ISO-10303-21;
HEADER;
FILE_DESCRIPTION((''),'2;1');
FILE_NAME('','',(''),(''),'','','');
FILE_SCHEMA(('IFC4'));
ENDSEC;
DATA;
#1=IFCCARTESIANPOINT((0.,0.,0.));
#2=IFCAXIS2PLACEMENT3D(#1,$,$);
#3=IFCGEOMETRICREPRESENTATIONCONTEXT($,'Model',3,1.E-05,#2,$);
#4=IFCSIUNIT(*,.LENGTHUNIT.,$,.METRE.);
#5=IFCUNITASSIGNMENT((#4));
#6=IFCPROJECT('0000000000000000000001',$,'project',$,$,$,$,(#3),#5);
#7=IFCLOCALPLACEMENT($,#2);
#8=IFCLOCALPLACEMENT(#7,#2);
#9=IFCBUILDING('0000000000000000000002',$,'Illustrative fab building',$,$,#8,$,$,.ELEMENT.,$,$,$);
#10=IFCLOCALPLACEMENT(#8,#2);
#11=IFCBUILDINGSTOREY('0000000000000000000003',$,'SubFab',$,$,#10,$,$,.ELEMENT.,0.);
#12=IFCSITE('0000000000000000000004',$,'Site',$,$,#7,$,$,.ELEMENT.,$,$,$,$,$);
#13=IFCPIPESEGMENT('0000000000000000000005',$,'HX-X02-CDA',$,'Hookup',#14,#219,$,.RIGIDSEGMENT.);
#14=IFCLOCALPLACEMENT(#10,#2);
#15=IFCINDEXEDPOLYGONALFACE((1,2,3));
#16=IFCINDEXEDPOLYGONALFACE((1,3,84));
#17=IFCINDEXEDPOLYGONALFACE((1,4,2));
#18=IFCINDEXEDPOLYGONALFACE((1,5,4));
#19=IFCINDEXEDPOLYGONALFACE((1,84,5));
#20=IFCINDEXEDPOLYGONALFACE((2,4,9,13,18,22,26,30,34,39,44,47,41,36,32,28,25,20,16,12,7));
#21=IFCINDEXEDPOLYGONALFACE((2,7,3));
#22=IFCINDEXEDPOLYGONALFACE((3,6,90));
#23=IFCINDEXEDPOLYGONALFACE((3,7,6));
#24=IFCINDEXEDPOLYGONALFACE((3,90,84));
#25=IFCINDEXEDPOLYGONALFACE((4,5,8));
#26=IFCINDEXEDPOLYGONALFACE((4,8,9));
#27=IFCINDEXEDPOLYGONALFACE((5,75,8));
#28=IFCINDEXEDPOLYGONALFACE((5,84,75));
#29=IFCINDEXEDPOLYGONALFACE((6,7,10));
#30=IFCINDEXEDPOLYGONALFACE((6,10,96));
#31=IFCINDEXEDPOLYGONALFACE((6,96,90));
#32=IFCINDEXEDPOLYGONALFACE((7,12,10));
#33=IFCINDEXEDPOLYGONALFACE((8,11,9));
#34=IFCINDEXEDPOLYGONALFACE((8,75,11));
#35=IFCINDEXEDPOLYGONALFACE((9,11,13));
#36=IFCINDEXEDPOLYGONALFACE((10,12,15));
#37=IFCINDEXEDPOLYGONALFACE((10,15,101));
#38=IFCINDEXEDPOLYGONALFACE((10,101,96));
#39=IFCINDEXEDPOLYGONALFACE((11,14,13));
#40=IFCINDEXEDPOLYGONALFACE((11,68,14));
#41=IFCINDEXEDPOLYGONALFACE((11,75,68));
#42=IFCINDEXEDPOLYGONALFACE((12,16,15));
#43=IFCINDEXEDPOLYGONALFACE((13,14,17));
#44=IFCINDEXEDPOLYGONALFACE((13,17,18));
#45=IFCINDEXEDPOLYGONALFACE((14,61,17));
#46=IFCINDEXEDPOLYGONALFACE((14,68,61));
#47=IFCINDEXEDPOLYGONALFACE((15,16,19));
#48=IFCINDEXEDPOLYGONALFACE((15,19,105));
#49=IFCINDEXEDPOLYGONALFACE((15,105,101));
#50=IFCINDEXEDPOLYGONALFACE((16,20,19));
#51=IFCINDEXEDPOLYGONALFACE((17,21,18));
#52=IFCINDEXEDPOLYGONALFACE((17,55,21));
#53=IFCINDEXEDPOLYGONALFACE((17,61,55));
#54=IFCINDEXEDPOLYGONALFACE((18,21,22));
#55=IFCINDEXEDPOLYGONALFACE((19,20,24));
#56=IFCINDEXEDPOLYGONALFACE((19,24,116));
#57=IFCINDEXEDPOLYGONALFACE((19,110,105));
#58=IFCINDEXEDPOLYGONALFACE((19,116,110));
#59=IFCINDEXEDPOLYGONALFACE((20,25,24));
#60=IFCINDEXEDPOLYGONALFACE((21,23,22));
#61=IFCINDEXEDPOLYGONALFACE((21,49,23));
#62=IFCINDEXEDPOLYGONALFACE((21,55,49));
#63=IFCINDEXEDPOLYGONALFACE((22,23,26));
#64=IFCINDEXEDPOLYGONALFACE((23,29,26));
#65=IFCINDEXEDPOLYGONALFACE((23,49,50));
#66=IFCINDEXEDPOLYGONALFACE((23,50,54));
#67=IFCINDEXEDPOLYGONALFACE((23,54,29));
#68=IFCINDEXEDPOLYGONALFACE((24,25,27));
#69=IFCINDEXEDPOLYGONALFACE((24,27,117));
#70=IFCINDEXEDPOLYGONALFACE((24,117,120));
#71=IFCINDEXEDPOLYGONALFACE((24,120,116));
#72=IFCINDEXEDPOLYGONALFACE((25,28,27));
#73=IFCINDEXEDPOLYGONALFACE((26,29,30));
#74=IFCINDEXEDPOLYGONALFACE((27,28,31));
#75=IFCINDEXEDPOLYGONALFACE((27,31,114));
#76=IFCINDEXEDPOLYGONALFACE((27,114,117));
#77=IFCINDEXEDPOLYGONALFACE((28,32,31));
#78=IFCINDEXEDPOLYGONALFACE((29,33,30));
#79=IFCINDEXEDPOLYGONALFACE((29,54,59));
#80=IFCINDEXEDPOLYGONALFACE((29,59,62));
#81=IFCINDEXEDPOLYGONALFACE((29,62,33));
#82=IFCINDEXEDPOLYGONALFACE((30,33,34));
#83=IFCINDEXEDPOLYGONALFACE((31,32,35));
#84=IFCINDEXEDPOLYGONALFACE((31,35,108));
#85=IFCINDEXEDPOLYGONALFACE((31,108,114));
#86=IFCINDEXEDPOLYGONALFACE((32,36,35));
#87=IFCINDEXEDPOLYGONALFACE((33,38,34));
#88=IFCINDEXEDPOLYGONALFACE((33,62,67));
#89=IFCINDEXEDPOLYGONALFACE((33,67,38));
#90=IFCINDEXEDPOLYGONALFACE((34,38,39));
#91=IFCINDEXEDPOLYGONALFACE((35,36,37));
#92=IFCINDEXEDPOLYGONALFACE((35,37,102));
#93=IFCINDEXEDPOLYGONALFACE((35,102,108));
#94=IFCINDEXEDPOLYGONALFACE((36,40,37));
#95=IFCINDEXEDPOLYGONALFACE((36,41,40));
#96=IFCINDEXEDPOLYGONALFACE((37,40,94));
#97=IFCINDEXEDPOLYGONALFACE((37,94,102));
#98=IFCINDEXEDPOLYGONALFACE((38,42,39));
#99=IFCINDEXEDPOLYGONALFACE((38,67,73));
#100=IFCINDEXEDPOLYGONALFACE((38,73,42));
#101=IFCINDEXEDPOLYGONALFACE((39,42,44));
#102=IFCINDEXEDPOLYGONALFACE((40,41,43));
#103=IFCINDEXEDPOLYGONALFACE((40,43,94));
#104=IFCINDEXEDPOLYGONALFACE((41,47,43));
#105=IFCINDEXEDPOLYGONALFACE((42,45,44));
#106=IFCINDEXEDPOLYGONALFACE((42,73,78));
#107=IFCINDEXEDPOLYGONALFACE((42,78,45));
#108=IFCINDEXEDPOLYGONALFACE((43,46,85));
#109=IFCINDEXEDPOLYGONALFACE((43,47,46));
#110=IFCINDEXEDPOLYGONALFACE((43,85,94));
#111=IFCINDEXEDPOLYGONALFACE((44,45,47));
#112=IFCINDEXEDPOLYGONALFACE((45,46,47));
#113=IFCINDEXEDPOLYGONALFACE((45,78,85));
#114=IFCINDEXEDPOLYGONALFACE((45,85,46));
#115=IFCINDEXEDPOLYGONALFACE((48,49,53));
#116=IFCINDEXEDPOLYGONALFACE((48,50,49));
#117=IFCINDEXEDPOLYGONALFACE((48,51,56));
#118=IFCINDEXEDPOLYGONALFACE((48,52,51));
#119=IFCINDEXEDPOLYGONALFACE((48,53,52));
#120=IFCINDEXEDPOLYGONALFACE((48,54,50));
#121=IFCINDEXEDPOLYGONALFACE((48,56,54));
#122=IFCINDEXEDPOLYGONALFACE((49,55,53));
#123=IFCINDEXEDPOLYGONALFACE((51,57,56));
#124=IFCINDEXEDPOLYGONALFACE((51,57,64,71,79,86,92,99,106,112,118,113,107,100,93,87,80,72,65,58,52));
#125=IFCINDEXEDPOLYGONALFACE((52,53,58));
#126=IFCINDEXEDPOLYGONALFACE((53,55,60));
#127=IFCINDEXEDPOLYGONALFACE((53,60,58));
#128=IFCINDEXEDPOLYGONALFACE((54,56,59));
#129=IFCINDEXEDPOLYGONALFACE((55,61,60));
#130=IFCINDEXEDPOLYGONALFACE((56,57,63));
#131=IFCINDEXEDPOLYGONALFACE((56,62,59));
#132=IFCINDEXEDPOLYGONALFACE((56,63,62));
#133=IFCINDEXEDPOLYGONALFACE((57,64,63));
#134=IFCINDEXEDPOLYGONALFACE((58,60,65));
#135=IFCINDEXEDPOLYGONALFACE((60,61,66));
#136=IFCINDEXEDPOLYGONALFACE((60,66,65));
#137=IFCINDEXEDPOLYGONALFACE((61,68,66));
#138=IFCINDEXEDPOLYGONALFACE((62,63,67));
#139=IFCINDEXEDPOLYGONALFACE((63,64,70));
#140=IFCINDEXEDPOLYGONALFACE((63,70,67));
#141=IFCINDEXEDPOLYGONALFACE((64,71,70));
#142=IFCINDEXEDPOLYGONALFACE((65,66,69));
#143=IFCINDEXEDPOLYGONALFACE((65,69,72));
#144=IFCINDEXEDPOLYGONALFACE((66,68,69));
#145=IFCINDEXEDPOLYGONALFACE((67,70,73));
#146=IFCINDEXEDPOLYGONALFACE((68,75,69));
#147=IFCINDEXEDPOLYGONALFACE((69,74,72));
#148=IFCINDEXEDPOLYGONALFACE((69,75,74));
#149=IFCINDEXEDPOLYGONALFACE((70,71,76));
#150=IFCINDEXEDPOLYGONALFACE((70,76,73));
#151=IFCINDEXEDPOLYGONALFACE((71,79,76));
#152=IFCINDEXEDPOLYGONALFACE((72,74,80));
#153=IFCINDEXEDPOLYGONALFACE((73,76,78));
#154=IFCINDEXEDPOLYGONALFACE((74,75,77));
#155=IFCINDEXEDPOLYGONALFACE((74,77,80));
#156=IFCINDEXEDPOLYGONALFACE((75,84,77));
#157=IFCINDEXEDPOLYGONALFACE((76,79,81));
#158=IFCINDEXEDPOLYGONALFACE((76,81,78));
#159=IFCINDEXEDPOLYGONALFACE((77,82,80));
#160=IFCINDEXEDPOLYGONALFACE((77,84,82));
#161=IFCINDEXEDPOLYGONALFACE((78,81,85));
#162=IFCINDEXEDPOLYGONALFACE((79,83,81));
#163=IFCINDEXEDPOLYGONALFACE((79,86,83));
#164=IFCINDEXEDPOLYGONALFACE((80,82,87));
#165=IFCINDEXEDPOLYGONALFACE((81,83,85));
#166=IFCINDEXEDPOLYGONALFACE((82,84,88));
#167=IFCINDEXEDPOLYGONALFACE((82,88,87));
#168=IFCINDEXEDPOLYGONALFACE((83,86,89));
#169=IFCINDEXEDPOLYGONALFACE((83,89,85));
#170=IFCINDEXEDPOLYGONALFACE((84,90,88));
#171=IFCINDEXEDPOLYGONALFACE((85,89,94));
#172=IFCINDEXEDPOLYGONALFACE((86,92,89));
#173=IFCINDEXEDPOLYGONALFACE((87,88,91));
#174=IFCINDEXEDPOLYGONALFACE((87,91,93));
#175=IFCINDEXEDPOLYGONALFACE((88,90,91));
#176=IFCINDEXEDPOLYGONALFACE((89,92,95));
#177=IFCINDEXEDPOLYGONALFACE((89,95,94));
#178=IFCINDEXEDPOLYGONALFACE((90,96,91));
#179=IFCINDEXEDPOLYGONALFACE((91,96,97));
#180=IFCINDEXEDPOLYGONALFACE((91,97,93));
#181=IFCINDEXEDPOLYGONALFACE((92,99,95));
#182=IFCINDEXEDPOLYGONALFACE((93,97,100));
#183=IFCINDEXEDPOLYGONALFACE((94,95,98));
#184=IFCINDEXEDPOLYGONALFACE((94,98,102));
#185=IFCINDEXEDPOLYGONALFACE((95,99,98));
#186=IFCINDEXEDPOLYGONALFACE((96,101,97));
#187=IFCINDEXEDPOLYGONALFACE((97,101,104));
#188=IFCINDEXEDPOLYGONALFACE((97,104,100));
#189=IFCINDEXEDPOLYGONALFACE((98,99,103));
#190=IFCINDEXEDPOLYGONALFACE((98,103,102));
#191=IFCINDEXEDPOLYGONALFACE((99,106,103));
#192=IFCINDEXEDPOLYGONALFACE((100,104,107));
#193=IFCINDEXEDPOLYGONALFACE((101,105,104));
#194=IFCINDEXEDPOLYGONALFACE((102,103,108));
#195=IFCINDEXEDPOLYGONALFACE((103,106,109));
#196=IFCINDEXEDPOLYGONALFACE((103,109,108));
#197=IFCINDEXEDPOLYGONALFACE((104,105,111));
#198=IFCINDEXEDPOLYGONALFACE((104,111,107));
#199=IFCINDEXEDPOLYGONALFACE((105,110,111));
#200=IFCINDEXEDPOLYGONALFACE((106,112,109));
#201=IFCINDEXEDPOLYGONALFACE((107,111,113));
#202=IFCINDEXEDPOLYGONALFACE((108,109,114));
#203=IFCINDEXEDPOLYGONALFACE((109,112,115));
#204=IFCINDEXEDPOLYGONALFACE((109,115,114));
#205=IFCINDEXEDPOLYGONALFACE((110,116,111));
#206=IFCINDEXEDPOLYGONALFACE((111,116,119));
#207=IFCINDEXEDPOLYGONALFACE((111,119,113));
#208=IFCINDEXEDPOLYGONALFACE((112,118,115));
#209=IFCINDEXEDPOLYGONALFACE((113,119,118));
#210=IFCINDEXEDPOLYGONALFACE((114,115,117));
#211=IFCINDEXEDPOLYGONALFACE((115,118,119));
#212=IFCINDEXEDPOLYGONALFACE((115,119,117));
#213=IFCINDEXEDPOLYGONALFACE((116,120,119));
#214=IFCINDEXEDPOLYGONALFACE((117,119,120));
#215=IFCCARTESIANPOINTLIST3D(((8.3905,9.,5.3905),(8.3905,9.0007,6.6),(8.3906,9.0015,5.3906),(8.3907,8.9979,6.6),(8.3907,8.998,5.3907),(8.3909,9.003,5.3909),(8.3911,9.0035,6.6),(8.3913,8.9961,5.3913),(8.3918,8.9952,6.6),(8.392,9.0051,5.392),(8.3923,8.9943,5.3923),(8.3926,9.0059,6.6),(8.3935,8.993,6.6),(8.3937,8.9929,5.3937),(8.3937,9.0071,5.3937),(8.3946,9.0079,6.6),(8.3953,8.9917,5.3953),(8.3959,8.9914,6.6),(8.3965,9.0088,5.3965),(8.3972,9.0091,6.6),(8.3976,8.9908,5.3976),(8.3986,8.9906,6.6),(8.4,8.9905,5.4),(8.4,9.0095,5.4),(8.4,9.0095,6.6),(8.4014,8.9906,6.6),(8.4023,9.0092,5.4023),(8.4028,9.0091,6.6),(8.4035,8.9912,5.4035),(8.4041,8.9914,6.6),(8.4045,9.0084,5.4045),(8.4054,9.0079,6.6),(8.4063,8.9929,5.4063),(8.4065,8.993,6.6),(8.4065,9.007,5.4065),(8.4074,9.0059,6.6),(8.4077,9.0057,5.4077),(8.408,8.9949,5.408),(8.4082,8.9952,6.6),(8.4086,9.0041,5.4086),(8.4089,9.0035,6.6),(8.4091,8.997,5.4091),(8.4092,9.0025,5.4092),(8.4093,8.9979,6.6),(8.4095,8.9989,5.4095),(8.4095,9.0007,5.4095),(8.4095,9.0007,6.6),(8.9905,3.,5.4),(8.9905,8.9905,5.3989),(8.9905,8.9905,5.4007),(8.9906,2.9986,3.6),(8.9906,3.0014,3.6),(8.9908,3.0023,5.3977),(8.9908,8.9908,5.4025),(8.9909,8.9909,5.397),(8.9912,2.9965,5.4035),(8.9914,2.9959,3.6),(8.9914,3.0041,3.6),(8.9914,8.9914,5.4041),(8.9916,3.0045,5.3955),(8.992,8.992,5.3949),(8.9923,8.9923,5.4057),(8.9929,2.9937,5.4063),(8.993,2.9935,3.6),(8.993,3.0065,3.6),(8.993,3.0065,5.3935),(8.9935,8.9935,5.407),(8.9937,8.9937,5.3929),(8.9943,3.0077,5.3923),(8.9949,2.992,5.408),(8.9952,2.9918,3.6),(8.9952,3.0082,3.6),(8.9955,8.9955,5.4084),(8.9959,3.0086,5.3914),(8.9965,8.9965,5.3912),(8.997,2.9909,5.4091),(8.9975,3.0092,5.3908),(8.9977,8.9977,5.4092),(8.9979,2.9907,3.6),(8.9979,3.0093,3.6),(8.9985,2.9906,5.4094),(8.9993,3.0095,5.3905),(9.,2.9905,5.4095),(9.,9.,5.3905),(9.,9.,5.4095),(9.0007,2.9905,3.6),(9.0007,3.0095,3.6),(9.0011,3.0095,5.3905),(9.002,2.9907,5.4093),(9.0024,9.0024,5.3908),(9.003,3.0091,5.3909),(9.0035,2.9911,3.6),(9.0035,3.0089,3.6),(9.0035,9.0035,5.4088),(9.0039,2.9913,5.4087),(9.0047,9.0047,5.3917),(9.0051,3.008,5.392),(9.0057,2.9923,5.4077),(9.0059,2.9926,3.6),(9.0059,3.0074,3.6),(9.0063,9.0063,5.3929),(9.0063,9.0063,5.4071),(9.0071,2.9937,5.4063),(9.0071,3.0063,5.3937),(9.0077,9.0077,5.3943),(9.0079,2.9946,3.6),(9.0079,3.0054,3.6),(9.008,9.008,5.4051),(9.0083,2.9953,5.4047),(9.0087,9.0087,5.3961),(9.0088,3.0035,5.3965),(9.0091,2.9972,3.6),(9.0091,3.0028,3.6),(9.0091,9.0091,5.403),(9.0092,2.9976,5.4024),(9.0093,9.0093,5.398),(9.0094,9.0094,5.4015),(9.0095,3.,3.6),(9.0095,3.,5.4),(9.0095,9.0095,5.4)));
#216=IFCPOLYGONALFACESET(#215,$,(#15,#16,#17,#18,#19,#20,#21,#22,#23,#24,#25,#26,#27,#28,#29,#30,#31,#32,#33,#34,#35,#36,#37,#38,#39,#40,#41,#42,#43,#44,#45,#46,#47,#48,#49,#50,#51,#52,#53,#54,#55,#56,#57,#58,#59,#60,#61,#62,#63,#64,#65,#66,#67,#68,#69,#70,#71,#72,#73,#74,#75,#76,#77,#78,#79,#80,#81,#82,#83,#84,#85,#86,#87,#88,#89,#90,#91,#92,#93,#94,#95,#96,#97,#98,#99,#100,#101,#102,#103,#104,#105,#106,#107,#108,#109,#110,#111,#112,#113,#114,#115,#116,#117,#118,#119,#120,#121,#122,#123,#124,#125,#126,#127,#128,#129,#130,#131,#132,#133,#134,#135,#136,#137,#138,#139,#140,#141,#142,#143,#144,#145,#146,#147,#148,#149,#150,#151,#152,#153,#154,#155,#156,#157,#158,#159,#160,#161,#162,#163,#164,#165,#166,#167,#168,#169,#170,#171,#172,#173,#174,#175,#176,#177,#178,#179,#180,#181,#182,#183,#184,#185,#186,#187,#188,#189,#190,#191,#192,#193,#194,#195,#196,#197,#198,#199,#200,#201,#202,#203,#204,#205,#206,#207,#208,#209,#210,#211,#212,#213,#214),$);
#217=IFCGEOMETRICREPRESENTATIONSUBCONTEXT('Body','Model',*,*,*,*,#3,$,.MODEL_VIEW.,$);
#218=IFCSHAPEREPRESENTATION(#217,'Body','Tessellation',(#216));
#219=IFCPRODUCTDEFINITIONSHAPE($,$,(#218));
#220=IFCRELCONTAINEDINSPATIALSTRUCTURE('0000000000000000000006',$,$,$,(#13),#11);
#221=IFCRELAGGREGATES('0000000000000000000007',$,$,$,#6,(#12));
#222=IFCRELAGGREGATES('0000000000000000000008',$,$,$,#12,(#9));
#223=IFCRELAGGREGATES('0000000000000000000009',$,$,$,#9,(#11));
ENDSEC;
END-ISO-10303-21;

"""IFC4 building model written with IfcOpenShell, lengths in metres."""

from ifc_helpers import new_model, entity, si_unit, origin, place, context, subcontext, project, spatial, element, save


model = new_model("IFC4")

# Units and contexts
model_context = context("Model", 3, precision=1e-05, world=origin())
body_context = subcontext(model_context, "Body", "Model", "MODEL_VIEW")
ifc_project = project(units=[si_unit("LENGTHUNIT", "METRE")], contexts=[model_context])

# Site, building, storey
site_placement = place(None, origin())
site = spatial("IfcSite", under=ifc_project, at=site_placement, Name="Site", CompositionType="ELEMENT")
building_placement = place(site_placement, origin())
building = spatial("IfcBuilding", under=site, at=building_placement, Name="Illustrative fab building", CompositionType="ELEMENT")
storey_placement = place(building_placement, origin())
storey = spatial("IfcBuildingStorey", under=building, at=storey_placement, Name="SubFab", CompositionType="ELEMENT", Elevation=0.0)

# Pipe segment
pipe_segment_1_placement = place(storey_placement, origin())
element("IfcPipeSegment", 1, at=pipe_segment_1_placement, inside=storey, Name="HX-X02-CDA", ObjectType="Hookup", PredefinedType="RIGIDSEGMENT", context=body_context, shape_type="AdvancedSweptSolid", body=[
    entity("IfcSweptDiskSolid", entity("IfcPolyline", [entity("IfcCartesianPoint", [9.0, 3.0, 3.6]), entity("IfcCartesianPoint", [9.0, 3.0, 5.4]), entity("IfcCartesianPoint", [9.0, 9.0, 5.4]), entity("IfcCartesianPoint", [8.4, 9.0, 5.4]), entity("IfcCartesianPoint", [8.4, 9.0, 6.6])]), 0.0095),
])

save(model, "model.ifc")
